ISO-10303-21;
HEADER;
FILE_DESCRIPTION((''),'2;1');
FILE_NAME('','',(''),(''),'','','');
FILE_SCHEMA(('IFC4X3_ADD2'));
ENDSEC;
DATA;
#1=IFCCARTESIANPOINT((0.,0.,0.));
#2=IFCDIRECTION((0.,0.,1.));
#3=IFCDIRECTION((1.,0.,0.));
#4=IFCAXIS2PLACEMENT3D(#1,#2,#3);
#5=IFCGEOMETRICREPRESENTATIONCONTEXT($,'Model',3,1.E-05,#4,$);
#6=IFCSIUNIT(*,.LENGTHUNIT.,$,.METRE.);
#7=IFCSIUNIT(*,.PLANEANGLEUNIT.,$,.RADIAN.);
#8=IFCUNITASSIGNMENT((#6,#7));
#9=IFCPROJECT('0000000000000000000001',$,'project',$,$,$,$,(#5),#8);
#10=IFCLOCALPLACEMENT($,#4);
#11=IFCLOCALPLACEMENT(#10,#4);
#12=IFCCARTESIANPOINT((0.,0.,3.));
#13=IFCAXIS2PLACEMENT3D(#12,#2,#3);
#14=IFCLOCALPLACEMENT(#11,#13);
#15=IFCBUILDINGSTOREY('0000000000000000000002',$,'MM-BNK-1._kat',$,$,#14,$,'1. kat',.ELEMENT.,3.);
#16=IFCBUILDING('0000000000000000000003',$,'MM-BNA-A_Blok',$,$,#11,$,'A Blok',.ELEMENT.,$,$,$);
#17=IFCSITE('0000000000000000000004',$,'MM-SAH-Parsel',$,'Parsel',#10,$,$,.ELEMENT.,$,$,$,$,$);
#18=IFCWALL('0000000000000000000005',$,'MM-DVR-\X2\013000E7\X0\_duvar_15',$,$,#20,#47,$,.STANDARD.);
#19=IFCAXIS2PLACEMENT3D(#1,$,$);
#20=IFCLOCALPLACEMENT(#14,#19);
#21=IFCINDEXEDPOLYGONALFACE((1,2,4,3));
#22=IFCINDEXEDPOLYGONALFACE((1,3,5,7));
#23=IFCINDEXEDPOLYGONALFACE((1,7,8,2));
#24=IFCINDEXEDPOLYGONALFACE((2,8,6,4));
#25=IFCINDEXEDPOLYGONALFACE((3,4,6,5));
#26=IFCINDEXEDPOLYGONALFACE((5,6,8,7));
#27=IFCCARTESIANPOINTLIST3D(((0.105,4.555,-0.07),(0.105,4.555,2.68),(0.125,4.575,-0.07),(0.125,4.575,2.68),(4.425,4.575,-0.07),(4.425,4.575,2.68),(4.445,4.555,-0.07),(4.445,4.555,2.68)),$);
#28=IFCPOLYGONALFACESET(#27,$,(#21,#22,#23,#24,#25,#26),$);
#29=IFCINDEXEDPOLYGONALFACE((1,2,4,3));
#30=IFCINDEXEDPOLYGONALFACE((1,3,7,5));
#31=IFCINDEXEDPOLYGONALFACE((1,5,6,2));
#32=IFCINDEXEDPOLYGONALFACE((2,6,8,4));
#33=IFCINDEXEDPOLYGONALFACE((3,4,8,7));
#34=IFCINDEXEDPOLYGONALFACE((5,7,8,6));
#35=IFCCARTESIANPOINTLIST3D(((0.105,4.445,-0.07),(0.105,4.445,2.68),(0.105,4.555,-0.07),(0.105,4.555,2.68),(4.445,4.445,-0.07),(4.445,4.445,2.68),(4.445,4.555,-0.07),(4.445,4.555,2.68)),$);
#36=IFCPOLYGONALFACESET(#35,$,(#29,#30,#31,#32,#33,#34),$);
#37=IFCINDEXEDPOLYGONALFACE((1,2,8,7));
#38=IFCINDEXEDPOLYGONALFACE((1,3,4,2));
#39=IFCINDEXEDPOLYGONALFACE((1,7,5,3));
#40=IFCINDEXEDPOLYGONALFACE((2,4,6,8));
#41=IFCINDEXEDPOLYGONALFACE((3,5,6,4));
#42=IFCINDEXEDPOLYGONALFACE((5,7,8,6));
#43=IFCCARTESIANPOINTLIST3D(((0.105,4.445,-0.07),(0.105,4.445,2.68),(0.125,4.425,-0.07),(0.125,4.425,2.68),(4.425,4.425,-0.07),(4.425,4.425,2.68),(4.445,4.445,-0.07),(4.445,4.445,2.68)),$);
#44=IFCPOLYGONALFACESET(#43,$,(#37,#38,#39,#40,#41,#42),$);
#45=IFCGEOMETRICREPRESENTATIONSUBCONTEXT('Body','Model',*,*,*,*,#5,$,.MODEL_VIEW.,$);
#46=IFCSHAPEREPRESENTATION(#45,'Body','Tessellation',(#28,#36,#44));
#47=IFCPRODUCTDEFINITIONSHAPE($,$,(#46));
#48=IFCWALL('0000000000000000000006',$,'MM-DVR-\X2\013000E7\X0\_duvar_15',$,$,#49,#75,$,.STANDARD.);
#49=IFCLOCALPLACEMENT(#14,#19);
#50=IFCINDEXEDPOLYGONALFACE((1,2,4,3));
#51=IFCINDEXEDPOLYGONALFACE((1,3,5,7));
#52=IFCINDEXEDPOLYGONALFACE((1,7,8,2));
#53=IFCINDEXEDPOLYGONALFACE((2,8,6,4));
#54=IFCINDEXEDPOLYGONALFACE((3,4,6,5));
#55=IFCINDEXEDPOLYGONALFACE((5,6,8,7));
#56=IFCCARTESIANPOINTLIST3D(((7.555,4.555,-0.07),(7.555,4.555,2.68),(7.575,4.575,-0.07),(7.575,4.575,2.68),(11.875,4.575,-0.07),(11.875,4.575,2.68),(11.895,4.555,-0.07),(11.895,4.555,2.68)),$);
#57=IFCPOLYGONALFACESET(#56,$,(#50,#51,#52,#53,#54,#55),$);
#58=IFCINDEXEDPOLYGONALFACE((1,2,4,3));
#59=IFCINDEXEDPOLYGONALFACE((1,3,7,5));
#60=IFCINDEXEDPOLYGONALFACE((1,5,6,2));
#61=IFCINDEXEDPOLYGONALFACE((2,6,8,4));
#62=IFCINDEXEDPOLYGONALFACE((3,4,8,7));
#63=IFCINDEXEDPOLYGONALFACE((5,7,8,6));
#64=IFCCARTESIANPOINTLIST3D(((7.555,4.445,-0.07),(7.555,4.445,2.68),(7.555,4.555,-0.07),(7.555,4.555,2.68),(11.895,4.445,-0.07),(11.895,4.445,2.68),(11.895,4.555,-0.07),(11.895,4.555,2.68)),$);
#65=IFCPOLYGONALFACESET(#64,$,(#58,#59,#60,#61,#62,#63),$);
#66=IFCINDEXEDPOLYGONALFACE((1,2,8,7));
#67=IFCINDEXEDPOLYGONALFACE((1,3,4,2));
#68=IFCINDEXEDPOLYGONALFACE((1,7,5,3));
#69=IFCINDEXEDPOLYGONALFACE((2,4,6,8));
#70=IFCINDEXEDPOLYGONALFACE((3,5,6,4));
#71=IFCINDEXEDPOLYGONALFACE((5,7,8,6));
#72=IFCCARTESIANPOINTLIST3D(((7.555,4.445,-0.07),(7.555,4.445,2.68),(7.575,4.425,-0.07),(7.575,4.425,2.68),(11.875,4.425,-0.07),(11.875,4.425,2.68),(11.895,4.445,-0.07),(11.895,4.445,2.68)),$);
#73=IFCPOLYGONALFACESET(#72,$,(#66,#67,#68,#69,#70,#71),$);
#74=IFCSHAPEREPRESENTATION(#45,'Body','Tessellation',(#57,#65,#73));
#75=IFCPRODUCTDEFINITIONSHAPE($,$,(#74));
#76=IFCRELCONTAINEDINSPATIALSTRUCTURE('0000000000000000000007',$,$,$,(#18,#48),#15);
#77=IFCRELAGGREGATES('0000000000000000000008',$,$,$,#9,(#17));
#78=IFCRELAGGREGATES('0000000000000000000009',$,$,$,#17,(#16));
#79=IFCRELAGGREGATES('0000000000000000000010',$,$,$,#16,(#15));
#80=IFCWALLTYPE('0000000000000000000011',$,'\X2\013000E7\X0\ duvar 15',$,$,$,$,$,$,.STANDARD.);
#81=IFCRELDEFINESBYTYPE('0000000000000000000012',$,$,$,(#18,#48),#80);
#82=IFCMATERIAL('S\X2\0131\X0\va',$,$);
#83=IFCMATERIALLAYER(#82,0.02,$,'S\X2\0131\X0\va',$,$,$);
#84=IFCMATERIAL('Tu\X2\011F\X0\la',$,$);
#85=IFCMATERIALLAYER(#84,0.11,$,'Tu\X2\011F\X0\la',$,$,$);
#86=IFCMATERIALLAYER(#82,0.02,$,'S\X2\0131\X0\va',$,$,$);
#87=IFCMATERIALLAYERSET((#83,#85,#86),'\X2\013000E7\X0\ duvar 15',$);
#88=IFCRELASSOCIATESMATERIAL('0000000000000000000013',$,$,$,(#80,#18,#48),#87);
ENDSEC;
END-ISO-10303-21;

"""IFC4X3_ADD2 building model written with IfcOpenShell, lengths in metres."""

from ifc_helpers import new_model, si_unit, frame, origin_with_axes, place, context, subcontext, project, spatial, polyline, outline, extrude, material, layer, layer_set, type_object, element, save


model = new_model("IFC4X3_ADD2")

# Units and contexts
model_context = context("Model", 3, precision=1e-05, world=origin_with_axes())
body_context = subcontext(model_context, "Body", "Model", "MODEL_VIEW")
ifc_project = project(units=[si_unit("LENGTHUNIT", "METRE"), si_unit("PLANEANGLEUNIT", "RADIAN")], contexts=[model_context])

# Site, building, storey
site_placement = place(None, origin_with_axes())
site = spatial("IfcSite", under=ifc_project, at=site_placement, Name="MM-SAH-Parsel", ObjectType="Parsel", CompositionType="ELEMENT")
building_placement = place(site_placement, origin_with_axes())
building = spatial("IfcBuilding", under=site, at=building_placement, Name="MM-BNA-A_Blok", LongName="A Blok", CompositionType="ELEMENT")
storey_placement = place(building_placement, frame((0.0, 0.0, 3.0), z_axis=(0.0, 0.0, 1.0), x_axis=(1.0, 0.0, 0.0)))
storey = spatial("IfcBuildingStorey", under=building, at=storey_placement, Name="MM-BNK-1._kat", LongName="1. kat", CompositionType="ELEMENT", Elevation=3.0)

# Shared definitions
ifc_material_1 = material(Name="Tuğla")

# Shared definitions
ifc_material_2 = material(Name="Sıva")
ifc_layer_1 = layer(ifc_material_2, 0.02, Name="Sıva")
ifc_layer_2 = layer(ifc_material_1, 0.11, Name="Tuğla")
ifc_layer_3 = layer(ifc_material_2, 0.02, Name="Sıva")
ifc_layer_set_1 = layer_set([ifc_layer_1, ifc_layer_2, ifc_layer_3], Name="İç duvar 15")
wall_type_1 = type_object("IfcWallType", Name="İç duvar 15", PredefinedType="STANDARD", material=ifc_layer_set_1)

# Walls
wall_1_placement = place(storey_placement, origin_with_axes())
element("IfcWall", 1, at=wall_1_placement, inside=storey, type_object=wall_type_1, material=ifc_layer_set_1, Name="MM-DVR-İç_duvar_15", PredefinedType="STANDARD", context=body_context, shape_type="SweptSolid", body=[
    extrude(outline(polyline([(0.125, 4.575), (4.425, 4.575), (4.445, 4.555), (0.105, 4.555), (0.125, 4.575)])), frame((0.0, 0.0, -0.07)), (0.0, 0.0, 1.0), 2.75),
    extrude(outline(polyline([(0.105, 4.555), (4.445, 4.555), (4.445, 4.445), (0.105, 4.445), (0.105, 4.555)])), frame((0.0, 0.0, -0.07)), (0.0, 0.0, 1.0), 2.75),
    extrude(outline(polyline([(0.105, 4.445), (4.445, 4.445), (4.425, 4.425), (0.125, 4.425), (0.105, 4.445)])), frame((0.0, 0.0, -0.07)), (0.0, 0.0, 1.0), 2.75),
])
wall_2_placement = place(storey_placement, origin_with_axes())
element("IfcWall", 2, at=wall_2_placement, inside=storey, type_object=wall_type_1, material=ifc_layer_set_1, Name="MM-DVR-İç_duvar_15", PredefinedType="STANDARD", context=body_context, shape_type="SweptSolid", body=[
    extrude(outline(polyline([(7.575, 4.575), (11.875, 4.575), (11.895, 4.555), (7.555, 4.555), (7.575, 4.575)])), frame((0.0, 0.0, -0.07)), (0.0, 0.0, 1.0), 2.75),
    extrude(outline(polyline([(7.555, 4.555), (11.895, 4.555), (11.895, 4.445), (7.555, 4.445), (7.555, 4.555)])), frame((0.0, 0.0, -0.07)), (0.0, 0.0, 1.0), 2.75),
    extrude(outline(polyline([(7.555, 4.445), (11.895, 4.445), (11.875, 4.425), (7.575, 4.425), (7.555, 4.445)])), frame((0.0, 0.0, -0.07)), (0.0, 0.0, 1.0), 2.75),
])

save(model, "model.ifc")
